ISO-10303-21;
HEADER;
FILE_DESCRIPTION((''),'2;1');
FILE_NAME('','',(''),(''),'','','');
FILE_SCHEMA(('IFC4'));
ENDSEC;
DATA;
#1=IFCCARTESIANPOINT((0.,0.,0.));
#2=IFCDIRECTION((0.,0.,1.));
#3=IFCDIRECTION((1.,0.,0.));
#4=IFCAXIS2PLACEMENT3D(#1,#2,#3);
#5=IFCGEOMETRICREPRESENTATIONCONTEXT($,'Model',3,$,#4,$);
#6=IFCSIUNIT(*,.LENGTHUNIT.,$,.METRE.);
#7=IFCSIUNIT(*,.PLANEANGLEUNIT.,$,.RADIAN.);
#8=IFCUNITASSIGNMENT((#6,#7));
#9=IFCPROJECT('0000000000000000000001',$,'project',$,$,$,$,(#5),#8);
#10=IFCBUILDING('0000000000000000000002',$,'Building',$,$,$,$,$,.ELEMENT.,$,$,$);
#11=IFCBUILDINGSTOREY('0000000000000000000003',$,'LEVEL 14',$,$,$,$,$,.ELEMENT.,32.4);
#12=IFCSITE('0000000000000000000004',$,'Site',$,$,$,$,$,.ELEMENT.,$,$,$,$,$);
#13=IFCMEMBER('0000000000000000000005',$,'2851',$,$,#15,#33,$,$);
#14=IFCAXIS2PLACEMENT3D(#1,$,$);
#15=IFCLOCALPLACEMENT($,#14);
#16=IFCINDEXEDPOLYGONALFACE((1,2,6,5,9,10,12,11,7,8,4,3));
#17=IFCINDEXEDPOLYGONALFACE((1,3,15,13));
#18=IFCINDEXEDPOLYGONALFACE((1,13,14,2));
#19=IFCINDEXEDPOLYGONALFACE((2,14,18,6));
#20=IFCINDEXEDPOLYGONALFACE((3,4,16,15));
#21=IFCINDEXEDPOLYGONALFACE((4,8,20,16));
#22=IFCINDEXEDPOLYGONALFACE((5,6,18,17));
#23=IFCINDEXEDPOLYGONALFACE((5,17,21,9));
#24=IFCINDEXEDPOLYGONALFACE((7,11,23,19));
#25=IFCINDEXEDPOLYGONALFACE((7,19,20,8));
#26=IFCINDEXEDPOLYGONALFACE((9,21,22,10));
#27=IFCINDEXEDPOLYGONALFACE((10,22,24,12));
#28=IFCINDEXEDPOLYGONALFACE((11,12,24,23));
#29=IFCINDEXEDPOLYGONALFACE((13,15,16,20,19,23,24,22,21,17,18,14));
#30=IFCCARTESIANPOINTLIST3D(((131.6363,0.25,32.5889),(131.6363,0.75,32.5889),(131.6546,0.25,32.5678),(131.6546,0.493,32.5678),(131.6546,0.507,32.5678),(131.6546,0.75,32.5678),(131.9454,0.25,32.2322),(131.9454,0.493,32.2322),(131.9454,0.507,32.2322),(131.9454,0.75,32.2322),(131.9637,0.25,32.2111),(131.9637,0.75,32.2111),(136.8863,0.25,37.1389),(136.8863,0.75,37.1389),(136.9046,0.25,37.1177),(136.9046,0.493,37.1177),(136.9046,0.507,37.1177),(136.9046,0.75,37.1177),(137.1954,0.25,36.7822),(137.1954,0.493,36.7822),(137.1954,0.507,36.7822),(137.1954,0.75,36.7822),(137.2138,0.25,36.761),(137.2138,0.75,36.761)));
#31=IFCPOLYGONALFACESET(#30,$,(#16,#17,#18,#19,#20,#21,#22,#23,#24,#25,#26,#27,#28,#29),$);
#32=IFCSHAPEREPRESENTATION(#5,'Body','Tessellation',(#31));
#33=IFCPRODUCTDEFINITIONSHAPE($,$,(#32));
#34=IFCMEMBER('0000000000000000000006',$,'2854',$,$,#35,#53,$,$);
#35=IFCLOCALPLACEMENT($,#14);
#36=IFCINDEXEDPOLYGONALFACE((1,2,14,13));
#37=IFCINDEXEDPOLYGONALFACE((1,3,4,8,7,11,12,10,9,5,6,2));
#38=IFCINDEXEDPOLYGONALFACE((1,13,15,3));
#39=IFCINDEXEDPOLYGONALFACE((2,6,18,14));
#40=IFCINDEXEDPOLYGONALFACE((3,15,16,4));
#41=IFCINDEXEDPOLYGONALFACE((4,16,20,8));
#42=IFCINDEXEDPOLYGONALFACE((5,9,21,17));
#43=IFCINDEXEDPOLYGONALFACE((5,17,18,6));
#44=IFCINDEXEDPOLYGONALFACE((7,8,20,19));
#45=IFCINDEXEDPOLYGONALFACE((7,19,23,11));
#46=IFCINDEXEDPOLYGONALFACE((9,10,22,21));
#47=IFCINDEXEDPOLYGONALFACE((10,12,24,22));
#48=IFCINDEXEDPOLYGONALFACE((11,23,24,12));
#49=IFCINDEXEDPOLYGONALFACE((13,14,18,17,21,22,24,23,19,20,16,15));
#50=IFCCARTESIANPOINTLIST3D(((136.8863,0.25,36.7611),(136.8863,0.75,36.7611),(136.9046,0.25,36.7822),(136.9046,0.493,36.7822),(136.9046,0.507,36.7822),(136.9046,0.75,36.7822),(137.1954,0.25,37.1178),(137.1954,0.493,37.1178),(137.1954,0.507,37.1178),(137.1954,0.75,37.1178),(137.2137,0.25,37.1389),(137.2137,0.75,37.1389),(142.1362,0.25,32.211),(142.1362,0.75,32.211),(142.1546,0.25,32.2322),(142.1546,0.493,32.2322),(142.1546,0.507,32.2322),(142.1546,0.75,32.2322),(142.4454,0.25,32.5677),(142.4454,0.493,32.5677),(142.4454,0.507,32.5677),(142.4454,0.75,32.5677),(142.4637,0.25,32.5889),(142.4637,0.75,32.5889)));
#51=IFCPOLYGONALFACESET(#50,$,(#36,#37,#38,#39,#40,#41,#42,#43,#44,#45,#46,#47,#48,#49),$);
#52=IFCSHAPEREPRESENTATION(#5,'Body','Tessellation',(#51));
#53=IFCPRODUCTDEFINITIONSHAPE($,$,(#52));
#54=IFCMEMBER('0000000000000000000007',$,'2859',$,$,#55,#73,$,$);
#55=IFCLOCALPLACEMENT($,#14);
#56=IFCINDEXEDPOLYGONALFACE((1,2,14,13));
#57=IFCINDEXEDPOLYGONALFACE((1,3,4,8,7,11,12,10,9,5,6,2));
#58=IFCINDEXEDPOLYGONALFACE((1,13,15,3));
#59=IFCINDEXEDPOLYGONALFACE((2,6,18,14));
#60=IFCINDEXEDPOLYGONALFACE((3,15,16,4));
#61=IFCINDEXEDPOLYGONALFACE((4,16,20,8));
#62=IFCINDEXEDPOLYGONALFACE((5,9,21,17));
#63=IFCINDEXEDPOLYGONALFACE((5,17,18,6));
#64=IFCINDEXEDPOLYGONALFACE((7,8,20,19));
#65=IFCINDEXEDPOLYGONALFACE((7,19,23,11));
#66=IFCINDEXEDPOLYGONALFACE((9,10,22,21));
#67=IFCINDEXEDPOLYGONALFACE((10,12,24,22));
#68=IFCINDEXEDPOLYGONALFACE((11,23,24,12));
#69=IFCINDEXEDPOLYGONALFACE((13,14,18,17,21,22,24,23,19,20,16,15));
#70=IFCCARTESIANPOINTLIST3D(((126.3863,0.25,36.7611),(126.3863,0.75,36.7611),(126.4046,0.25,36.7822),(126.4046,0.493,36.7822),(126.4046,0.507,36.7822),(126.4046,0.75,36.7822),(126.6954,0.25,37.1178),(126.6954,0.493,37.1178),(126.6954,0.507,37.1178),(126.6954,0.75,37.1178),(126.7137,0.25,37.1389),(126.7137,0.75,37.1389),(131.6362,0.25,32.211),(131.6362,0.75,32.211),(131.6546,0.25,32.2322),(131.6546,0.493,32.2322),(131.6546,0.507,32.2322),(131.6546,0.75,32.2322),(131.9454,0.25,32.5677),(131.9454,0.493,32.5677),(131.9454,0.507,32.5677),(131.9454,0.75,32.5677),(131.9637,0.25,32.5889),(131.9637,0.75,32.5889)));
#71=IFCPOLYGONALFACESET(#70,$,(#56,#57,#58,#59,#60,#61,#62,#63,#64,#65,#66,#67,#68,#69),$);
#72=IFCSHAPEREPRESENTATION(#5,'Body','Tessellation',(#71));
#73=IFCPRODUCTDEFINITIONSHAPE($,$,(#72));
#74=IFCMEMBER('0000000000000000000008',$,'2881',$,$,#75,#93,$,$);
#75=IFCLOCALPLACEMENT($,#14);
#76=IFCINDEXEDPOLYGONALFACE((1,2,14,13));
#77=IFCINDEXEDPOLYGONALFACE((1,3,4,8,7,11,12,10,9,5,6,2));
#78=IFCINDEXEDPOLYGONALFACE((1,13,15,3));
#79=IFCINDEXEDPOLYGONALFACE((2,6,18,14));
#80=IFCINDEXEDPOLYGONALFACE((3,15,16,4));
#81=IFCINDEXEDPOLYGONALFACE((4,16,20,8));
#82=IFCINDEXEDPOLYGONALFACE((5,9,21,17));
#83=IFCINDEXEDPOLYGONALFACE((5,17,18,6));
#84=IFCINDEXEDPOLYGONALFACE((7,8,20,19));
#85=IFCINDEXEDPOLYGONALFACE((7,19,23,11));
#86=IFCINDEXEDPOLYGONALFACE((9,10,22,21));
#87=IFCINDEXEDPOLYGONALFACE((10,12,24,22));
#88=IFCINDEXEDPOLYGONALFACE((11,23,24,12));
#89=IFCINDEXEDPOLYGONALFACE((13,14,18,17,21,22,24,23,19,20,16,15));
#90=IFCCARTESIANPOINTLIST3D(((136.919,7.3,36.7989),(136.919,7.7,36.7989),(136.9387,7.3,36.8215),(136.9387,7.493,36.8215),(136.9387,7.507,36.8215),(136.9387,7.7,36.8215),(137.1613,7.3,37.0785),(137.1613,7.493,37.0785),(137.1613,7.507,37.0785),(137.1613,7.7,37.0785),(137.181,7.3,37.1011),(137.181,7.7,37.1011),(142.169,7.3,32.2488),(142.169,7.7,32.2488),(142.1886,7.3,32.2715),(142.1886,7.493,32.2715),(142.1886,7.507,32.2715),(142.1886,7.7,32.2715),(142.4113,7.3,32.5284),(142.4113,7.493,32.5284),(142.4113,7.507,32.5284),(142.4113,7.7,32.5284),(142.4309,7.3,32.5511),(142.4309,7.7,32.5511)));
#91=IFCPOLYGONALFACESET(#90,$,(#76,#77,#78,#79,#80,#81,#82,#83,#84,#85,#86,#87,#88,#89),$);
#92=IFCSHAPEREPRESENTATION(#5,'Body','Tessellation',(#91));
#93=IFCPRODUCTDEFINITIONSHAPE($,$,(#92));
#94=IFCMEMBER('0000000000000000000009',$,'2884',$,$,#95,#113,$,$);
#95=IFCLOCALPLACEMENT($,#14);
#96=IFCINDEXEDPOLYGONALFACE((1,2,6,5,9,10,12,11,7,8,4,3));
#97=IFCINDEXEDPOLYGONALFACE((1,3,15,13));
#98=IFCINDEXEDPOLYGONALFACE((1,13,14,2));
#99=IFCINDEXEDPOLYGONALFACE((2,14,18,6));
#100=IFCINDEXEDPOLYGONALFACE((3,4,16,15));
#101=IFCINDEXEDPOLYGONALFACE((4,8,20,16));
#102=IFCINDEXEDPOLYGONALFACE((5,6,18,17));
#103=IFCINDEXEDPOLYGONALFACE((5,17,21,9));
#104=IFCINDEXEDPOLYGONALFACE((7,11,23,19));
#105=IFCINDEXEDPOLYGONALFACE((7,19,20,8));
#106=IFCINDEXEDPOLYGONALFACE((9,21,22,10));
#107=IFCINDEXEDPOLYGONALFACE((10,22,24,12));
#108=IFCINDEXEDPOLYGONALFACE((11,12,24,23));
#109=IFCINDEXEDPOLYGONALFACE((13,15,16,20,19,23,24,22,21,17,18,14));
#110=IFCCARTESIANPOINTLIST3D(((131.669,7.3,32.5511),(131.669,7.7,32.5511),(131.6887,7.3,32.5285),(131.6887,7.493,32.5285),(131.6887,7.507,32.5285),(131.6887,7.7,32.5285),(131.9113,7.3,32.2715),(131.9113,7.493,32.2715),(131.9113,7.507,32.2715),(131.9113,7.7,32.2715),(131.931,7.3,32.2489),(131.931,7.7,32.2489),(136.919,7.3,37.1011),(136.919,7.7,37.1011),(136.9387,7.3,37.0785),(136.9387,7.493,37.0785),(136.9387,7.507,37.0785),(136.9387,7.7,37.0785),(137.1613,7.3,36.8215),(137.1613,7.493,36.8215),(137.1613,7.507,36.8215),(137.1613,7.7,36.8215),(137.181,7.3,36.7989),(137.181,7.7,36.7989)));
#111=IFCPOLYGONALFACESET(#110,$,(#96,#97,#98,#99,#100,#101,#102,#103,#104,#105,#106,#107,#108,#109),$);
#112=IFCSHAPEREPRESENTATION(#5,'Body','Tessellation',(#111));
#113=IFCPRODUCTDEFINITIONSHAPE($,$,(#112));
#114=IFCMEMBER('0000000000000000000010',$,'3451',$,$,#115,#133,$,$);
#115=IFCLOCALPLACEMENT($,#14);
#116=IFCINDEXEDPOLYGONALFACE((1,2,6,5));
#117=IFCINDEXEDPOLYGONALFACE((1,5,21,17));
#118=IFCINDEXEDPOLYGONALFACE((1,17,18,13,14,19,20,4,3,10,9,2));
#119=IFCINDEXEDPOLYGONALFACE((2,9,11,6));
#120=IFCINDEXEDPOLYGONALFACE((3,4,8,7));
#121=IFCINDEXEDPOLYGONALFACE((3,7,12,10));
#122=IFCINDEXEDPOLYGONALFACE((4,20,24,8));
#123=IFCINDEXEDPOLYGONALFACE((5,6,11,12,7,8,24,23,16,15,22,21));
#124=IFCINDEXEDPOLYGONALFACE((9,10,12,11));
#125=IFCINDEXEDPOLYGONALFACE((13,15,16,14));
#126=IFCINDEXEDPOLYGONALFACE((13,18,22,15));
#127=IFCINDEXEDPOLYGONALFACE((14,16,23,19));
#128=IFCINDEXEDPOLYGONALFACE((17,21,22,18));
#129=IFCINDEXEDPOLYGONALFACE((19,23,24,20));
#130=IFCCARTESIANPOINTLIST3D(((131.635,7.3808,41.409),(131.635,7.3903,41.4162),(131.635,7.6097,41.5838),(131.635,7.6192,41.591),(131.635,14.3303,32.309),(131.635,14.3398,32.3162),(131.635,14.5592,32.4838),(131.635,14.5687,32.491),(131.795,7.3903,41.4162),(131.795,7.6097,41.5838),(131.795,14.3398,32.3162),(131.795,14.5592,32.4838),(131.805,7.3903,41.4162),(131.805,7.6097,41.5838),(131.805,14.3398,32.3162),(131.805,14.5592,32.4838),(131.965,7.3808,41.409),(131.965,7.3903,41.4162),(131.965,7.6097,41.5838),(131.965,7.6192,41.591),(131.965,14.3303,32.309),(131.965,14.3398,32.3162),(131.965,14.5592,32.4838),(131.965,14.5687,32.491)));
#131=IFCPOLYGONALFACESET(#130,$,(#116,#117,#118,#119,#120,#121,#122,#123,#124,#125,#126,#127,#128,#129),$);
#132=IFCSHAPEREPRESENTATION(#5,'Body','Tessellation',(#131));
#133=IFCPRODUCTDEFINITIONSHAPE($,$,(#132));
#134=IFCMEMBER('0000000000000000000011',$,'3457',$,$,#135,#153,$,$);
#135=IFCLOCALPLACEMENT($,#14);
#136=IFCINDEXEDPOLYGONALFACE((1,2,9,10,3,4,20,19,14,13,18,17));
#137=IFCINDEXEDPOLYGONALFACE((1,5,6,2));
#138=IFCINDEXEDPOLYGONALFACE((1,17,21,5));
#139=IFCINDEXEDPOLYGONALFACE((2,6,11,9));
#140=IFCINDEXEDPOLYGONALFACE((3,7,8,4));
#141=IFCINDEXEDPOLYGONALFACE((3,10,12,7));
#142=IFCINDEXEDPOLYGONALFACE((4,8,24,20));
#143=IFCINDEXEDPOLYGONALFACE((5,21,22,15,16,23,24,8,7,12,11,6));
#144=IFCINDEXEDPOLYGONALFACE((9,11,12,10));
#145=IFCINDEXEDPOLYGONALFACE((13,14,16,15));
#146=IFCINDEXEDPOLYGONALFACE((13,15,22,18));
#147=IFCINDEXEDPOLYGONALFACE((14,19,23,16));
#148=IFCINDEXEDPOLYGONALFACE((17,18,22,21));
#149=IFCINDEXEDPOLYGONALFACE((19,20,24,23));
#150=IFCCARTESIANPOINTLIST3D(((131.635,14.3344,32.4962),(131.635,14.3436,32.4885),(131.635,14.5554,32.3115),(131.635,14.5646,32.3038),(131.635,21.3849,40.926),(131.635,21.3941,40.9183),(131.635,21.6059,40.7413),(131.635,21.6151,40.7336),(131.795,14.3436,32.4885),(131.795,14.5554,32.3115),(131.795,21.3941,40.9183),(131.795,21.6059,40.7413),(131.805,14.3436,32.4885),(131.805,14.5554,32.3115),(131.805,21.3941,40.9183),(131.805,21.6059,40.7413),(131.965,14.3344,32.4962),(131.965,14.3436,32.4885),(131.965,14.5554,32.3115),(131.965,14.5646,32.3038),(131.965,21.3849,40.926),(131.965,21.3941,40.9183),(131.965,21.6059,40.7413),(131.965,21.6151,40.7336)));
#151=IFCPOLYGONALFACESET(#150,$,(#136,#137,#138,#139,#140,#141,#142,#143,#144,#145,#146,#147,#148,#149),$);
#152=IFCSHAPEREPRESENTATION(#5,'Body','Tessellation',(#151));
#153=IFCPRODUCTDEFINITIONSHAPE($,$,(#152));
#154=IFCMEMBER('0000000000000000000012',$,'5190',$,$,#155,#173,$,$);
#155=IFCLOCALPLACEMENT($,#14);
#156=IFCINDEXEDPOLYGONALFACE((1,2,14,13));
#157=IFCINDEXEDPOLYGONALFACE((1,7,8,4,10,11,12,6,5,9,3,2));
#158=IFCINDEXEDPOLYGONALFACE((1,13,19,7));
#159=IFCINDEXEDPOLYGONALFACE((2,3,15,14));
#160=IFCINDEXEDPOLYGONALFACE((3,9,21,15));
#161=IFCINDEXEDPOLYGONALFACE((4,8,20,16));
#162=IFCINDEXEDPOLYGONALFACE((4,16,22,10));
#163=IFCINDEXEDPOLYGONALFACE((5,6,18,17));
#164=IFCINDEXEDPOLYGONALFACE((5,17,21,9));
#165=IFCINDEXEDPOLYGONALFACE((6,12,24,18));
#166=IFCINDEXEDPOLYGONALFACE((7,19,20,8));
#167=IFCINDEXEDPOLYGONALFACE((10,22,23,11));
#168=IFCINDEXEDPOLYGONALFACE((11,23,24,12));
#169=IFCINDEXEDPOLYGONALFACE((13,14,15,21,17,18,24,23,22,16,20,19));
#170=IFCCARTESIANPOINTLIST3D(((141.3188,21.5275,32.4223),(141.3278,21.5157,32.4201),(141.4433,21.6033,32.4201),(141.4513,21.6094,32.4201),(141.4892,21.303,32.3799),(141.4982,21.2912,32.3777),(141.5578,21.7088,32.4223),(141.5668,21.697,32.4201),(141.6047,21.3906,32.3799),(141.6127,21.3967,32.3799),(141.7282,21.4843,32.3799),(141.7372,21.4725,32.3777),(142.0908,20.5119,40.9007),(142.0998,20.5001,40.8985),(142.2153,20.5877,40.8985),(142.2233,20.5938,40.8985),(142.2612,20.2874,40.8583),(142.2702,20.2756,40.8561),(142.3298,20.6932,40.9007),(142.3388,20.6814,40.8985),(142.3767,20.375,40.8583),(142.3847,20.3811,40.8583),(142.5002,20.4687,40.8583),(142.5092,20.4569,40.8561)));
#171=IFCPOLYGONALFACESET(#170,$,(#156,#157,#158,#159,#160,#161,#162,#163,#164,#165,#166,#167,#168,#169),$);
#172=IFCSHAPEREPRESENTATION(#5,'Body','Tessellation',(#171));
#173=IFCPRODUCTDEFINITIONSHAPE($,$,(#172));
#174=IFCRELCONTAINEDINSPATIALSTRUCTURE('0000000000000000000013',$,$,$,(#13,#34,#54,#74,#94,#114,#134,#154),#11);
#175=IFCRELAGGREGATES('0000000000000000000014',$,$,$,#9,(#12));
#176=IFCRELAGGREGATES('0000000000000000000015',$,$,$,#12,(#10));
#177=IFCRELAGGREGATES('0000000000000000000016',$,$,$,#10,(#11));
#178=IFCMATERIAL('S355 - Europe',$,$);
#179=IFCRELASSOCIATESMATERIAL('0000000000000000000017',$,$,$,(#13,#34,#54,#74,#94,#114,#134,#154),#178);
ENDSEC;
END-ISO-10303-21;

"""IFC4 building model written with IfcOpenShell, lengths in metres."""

from ifc_helpers import new_model, si_unit, frame, origin_with_axes, origin_2d_with_axis, place, context, project, spatial, i_section, extrude, material, material_profile, profile_set, profile_usage, element, save


model = new_model("IFC4")

# Units and contexts
model_context = context("Model", 3, world=origin_with_axes())
ifc_project = project(units=[si_unit("LENGTHUNIT", "METRE"), si_unit("PLANEANGLEUNIT", "RADIAN")], contexts=[model_context])

# Site, building, storey
site = spatial("IfcSite", under=ifc_project, Name="Site", CompositionType="ELEMENT")
building = spatial("IfcBuilding", under=site, Name="Building", CompositionType="ELEMENT")
storey = spatial("IfcBuildingStorey", under=building, Name="LEVEL 14", CompositionType="ELEMENT", Elevation=32.4)

# Shared definitions
ifc_material = material(Name="S355 - Europe")

# Members
ifc_material_profile_1 = material_profile(ifc_material, i_section(OverallWidth=0.5, OverallDepth=0.5, WebThickness=0.014, FlangeThickness=0.028, at=origin_2d_with_axis()))
ifc_profile_set_1 = profile_set([ifc_material_profile_1])
ifc_profile_usage_1 = profile_usage(ifc_profile_set_1, cardinal=10)
member_1_placement = place(None, frame((131.8, 0.5, 32.4), z_axis=(0.755695, 0.0, 0.654923), x_axis=(0.0, 1.0, 0.0)))
element("IfcMember", 1, at=member_1_placement, inside=storey, material=ifc_profile_usage_1, Name="2851", context=model_context, shape_type="SweptSolid", body=[
    extrude(i_section(OverallWidth=0.5, OverallDepth=0.5, WebThickness=0.014, FlangeThickness=0.028, at=origin_2d_with_axis()), origin_with_axes(), (0.0, 0.0, 1.0), 6.9473),
])
ifc_material_profile_2 = material_profile(ifc_material, i_section(OverallWidth=0.5, OverallDepth=0.5, WebThickness=0.014, FlangeThickness=0.028, at=origin_2d_with_axis()))
ifc_profile_set_2 = profile_set([ifc_material_profile_2])
ifc_profile_usage_2 = profile_usage(ifc_profile_set_2, cardinal=10)
member_2_placement = place(None, frame((137.05, 0.5, 36.95), z_axis=(0.755683, 0.0, -0.654938), x_axis=(0.0, 1.0, 0.0)))
element("IfcMember", 2, at=member_2_placement, inside=storey, material=ifc_profile_usage_2, Name="2854", context=model_context, shape_type="SweptSolid", body=[
    extrude(i_section(OverallWidth=0.5, OverallDepth=0.5, WebThickness=0.014, FlangeThickness=0.028, at=origin_2d_with_axis()), origin_with_axes(), (0.0, 0.0, 1.0), 6.9473),
])
ifc_material_profile_3 = material_profile(ifc_material, i_section(OverallWidth=0.5, OverallDepth=0.5, WebThickness=0.014, FlangeThickness=0.028, at=origin_2d_with_axis()))
ifc_profile_set_3 = profile_set([ifc_material_profile_3])
ifc_profile_usage_3 = profile_usage(ifc_profile_set_3, cardinal=10)
member_3_placement = place(None, frame((126.55, 0.5, 36.95), z_axis=(0.755683, 0.0, -0.654938), x_axis=(0.0, 1.0, 0.0)))
element("IfcMember", 3, at=member_3_placement, inside=storey, material=ifc_profile_usage_3, Name="2859", context=model_context, shape_type="SweptSolid", body=[
    extrude(i_section(OverallWidth=0.5, OverallDepth=0.5, WebThickness=0.014, FlangeThickness=0.028, at=origin_2d_with_axis()), origin_with_axes(), (0.0, 0.0, 1.0), 6.9473),
])
ifc_material_profile_4 = material_profile(ifc_material, i_section(OverallWidth=0.4, OverallDepth=0.4, WebThickness=0.014, FlangeThickness=0.03, at=origin_2d_with_axis()))
ifc_profile_set_4 = profile_set([ifc_material_profile_4])
ifc_profile_usage_4 = profile_usage(ifc_profile_set_4, cardinal=10)
member_4_placement = place(None, frame((137.05, 7.5, 36.95), z_axis=(0.755683, 0.0, -0.654938), x_axis=(0.0, 1.0, 0.0)))
element("IfcMember", 4, at=member_4_placement, inside=storey, material=ifc_profile_usage_4, Name="2881", context=model_context, shape_type="SweptSolid", body=[
    extrude(i_section(OverallWidth=0.4, OverallDepth=0.4, WebThickness=0.014, FlangeThickness=0.03, at=origin_2d_with_axis()), origin_with_axes(), (0.0, 0.0, 1.0), 6.9473),
])
ifc_material_profile_5 = material_profile(ifc_material, i_section(OverallWidth=0.4, OverallDepth=0.4, WebThickness=0.014, FlangeThickness=0.03, at=origin_2d_with_axis()))
ifc_profile_set_5 = profile_set([ifc_material_profile_5])
ifc_profile_usage_5 = profile_usage(ifc_profile_set_5, cardinal=10)
member_5_placement = place(None, frame((137.05, 7.5, 36.95), z_axis=(-0.755689, 0.0, -0.654931), x_axis=(0.0, -1.0, 0.0)))
element("IfcMember", 5, at=member_5_placement, inside=storey, material=ifc_profile_usage_5, Name="2884", context=model_context, shape_type="SweptSolid", body=[
    extrude(i_section(OverallWidth=0.4, OverallDepth=0.4, WebThickness=0.014, FlangeThickness=0.03, at=origin_2d_with_axis()), origin_with_axes(), (0.0, 0.0, 1.0), 6.9473),
])
ifc_material_profile_6 = material_profile(ifc_material, i_section(OverallWidth=0.33, OverallDepth=0.3, WebThickness=0.01, FlangeThickness=0.012, at=origin_2d_with_axis()))
ifc_profile_set_6 = profile_set([ifc_material_profile_6])
ifc_profile_usage_6 = profile_usage(ifc_profile_set_6, cardinal=10)
member_6_placement = place(None, frame((131.8, 7.5, 41.5), z_axis=(0.0, 0.606936, -0.794751), x_axis=(-1.0, 0.0, 0.0)))
element("IfcMember", 6, at=member_6_placement, inside=storey, material=ifc_profile_usage_6, Name="3451", context=model_context, shape_type="SweptSolid", body=[
    extrude(i_section(OverallWidth=0.33, OverallDepth=0.3, WebThickness=0.01, FlangeThickness=0.012, at=origin_2d_with_axis()), origin_with_axes(), (0.0, 0.0, 1.0), 11.4501),
])
ifc_material_profile_7 = material_profile(ifc_material, i_section(OverallWidth=0.33, OverallDepth=0.3, WebThickness=0.01, FlangeThickness=0.012, at=origin_2d_with_axis()))
ifc_profile_set_7 = profile_set([ifc_material_profile_7])
ifc_profile_usage_7 = profile_usage(ifc_profile_set_7, cardinal=10)
member_7_placement = place(None, frame((131.8, 21.5, 40.8298), z_axis=(0.0, -0.641562, -0.767071), x_axis=(1.0, 0.0, 0.0)))
element("IfcMember", 7, at=member_7_placement, inside=storey, material=ifc_profile_usage_7, Name="3457", context=model_context, shape_type="SweptSolid", body=[
    extrude(i_section(OverallWidth=0.33, OverallDepth=0.3, WebThickness=0.01, FlangeThickness=0.012, at=origin_2d_with_axis()), origin_with_axes(), (0.0, 0.0, 1.0), 10.9896),
])
ifc_material_profile_8 = material_profile(ifc_material, i_section(OverallWidth=0.3, OverallDepth=0.3, WebThickness=0.01, FlangeThickness=0.015, at=origin_2d_with_axis()))
ifc_profile_set_8 = profile_set([ifc_material_profile_8])
ifc_profile_usage_8 = profile_usage(ifc_profile_set_8, cardinal=10)
member_8_placement = place(None, frame((141.528, 21.5, 32.4), z_axis=(0.090041, -0.118453, 0.988869), x_axis=(0.796587, 0.604524, 0.0)))
element("IfcMember", 8, at=member_8_placement, inside=storey, material=ifc_profile_usage_8, Name="5190", context=model_context, shape_type="SweptSolid", body=[
    extrude(i_section(OverallWidth=0.3, OverallDepth=0.3, WebThickness=0.01, FlangeThickness=0.015, at=origin_2d_with_axis()), origin_with_axes(), (0.0, 0.0, 1.0), 8.5738),
])

save(model, "model.ifc")
